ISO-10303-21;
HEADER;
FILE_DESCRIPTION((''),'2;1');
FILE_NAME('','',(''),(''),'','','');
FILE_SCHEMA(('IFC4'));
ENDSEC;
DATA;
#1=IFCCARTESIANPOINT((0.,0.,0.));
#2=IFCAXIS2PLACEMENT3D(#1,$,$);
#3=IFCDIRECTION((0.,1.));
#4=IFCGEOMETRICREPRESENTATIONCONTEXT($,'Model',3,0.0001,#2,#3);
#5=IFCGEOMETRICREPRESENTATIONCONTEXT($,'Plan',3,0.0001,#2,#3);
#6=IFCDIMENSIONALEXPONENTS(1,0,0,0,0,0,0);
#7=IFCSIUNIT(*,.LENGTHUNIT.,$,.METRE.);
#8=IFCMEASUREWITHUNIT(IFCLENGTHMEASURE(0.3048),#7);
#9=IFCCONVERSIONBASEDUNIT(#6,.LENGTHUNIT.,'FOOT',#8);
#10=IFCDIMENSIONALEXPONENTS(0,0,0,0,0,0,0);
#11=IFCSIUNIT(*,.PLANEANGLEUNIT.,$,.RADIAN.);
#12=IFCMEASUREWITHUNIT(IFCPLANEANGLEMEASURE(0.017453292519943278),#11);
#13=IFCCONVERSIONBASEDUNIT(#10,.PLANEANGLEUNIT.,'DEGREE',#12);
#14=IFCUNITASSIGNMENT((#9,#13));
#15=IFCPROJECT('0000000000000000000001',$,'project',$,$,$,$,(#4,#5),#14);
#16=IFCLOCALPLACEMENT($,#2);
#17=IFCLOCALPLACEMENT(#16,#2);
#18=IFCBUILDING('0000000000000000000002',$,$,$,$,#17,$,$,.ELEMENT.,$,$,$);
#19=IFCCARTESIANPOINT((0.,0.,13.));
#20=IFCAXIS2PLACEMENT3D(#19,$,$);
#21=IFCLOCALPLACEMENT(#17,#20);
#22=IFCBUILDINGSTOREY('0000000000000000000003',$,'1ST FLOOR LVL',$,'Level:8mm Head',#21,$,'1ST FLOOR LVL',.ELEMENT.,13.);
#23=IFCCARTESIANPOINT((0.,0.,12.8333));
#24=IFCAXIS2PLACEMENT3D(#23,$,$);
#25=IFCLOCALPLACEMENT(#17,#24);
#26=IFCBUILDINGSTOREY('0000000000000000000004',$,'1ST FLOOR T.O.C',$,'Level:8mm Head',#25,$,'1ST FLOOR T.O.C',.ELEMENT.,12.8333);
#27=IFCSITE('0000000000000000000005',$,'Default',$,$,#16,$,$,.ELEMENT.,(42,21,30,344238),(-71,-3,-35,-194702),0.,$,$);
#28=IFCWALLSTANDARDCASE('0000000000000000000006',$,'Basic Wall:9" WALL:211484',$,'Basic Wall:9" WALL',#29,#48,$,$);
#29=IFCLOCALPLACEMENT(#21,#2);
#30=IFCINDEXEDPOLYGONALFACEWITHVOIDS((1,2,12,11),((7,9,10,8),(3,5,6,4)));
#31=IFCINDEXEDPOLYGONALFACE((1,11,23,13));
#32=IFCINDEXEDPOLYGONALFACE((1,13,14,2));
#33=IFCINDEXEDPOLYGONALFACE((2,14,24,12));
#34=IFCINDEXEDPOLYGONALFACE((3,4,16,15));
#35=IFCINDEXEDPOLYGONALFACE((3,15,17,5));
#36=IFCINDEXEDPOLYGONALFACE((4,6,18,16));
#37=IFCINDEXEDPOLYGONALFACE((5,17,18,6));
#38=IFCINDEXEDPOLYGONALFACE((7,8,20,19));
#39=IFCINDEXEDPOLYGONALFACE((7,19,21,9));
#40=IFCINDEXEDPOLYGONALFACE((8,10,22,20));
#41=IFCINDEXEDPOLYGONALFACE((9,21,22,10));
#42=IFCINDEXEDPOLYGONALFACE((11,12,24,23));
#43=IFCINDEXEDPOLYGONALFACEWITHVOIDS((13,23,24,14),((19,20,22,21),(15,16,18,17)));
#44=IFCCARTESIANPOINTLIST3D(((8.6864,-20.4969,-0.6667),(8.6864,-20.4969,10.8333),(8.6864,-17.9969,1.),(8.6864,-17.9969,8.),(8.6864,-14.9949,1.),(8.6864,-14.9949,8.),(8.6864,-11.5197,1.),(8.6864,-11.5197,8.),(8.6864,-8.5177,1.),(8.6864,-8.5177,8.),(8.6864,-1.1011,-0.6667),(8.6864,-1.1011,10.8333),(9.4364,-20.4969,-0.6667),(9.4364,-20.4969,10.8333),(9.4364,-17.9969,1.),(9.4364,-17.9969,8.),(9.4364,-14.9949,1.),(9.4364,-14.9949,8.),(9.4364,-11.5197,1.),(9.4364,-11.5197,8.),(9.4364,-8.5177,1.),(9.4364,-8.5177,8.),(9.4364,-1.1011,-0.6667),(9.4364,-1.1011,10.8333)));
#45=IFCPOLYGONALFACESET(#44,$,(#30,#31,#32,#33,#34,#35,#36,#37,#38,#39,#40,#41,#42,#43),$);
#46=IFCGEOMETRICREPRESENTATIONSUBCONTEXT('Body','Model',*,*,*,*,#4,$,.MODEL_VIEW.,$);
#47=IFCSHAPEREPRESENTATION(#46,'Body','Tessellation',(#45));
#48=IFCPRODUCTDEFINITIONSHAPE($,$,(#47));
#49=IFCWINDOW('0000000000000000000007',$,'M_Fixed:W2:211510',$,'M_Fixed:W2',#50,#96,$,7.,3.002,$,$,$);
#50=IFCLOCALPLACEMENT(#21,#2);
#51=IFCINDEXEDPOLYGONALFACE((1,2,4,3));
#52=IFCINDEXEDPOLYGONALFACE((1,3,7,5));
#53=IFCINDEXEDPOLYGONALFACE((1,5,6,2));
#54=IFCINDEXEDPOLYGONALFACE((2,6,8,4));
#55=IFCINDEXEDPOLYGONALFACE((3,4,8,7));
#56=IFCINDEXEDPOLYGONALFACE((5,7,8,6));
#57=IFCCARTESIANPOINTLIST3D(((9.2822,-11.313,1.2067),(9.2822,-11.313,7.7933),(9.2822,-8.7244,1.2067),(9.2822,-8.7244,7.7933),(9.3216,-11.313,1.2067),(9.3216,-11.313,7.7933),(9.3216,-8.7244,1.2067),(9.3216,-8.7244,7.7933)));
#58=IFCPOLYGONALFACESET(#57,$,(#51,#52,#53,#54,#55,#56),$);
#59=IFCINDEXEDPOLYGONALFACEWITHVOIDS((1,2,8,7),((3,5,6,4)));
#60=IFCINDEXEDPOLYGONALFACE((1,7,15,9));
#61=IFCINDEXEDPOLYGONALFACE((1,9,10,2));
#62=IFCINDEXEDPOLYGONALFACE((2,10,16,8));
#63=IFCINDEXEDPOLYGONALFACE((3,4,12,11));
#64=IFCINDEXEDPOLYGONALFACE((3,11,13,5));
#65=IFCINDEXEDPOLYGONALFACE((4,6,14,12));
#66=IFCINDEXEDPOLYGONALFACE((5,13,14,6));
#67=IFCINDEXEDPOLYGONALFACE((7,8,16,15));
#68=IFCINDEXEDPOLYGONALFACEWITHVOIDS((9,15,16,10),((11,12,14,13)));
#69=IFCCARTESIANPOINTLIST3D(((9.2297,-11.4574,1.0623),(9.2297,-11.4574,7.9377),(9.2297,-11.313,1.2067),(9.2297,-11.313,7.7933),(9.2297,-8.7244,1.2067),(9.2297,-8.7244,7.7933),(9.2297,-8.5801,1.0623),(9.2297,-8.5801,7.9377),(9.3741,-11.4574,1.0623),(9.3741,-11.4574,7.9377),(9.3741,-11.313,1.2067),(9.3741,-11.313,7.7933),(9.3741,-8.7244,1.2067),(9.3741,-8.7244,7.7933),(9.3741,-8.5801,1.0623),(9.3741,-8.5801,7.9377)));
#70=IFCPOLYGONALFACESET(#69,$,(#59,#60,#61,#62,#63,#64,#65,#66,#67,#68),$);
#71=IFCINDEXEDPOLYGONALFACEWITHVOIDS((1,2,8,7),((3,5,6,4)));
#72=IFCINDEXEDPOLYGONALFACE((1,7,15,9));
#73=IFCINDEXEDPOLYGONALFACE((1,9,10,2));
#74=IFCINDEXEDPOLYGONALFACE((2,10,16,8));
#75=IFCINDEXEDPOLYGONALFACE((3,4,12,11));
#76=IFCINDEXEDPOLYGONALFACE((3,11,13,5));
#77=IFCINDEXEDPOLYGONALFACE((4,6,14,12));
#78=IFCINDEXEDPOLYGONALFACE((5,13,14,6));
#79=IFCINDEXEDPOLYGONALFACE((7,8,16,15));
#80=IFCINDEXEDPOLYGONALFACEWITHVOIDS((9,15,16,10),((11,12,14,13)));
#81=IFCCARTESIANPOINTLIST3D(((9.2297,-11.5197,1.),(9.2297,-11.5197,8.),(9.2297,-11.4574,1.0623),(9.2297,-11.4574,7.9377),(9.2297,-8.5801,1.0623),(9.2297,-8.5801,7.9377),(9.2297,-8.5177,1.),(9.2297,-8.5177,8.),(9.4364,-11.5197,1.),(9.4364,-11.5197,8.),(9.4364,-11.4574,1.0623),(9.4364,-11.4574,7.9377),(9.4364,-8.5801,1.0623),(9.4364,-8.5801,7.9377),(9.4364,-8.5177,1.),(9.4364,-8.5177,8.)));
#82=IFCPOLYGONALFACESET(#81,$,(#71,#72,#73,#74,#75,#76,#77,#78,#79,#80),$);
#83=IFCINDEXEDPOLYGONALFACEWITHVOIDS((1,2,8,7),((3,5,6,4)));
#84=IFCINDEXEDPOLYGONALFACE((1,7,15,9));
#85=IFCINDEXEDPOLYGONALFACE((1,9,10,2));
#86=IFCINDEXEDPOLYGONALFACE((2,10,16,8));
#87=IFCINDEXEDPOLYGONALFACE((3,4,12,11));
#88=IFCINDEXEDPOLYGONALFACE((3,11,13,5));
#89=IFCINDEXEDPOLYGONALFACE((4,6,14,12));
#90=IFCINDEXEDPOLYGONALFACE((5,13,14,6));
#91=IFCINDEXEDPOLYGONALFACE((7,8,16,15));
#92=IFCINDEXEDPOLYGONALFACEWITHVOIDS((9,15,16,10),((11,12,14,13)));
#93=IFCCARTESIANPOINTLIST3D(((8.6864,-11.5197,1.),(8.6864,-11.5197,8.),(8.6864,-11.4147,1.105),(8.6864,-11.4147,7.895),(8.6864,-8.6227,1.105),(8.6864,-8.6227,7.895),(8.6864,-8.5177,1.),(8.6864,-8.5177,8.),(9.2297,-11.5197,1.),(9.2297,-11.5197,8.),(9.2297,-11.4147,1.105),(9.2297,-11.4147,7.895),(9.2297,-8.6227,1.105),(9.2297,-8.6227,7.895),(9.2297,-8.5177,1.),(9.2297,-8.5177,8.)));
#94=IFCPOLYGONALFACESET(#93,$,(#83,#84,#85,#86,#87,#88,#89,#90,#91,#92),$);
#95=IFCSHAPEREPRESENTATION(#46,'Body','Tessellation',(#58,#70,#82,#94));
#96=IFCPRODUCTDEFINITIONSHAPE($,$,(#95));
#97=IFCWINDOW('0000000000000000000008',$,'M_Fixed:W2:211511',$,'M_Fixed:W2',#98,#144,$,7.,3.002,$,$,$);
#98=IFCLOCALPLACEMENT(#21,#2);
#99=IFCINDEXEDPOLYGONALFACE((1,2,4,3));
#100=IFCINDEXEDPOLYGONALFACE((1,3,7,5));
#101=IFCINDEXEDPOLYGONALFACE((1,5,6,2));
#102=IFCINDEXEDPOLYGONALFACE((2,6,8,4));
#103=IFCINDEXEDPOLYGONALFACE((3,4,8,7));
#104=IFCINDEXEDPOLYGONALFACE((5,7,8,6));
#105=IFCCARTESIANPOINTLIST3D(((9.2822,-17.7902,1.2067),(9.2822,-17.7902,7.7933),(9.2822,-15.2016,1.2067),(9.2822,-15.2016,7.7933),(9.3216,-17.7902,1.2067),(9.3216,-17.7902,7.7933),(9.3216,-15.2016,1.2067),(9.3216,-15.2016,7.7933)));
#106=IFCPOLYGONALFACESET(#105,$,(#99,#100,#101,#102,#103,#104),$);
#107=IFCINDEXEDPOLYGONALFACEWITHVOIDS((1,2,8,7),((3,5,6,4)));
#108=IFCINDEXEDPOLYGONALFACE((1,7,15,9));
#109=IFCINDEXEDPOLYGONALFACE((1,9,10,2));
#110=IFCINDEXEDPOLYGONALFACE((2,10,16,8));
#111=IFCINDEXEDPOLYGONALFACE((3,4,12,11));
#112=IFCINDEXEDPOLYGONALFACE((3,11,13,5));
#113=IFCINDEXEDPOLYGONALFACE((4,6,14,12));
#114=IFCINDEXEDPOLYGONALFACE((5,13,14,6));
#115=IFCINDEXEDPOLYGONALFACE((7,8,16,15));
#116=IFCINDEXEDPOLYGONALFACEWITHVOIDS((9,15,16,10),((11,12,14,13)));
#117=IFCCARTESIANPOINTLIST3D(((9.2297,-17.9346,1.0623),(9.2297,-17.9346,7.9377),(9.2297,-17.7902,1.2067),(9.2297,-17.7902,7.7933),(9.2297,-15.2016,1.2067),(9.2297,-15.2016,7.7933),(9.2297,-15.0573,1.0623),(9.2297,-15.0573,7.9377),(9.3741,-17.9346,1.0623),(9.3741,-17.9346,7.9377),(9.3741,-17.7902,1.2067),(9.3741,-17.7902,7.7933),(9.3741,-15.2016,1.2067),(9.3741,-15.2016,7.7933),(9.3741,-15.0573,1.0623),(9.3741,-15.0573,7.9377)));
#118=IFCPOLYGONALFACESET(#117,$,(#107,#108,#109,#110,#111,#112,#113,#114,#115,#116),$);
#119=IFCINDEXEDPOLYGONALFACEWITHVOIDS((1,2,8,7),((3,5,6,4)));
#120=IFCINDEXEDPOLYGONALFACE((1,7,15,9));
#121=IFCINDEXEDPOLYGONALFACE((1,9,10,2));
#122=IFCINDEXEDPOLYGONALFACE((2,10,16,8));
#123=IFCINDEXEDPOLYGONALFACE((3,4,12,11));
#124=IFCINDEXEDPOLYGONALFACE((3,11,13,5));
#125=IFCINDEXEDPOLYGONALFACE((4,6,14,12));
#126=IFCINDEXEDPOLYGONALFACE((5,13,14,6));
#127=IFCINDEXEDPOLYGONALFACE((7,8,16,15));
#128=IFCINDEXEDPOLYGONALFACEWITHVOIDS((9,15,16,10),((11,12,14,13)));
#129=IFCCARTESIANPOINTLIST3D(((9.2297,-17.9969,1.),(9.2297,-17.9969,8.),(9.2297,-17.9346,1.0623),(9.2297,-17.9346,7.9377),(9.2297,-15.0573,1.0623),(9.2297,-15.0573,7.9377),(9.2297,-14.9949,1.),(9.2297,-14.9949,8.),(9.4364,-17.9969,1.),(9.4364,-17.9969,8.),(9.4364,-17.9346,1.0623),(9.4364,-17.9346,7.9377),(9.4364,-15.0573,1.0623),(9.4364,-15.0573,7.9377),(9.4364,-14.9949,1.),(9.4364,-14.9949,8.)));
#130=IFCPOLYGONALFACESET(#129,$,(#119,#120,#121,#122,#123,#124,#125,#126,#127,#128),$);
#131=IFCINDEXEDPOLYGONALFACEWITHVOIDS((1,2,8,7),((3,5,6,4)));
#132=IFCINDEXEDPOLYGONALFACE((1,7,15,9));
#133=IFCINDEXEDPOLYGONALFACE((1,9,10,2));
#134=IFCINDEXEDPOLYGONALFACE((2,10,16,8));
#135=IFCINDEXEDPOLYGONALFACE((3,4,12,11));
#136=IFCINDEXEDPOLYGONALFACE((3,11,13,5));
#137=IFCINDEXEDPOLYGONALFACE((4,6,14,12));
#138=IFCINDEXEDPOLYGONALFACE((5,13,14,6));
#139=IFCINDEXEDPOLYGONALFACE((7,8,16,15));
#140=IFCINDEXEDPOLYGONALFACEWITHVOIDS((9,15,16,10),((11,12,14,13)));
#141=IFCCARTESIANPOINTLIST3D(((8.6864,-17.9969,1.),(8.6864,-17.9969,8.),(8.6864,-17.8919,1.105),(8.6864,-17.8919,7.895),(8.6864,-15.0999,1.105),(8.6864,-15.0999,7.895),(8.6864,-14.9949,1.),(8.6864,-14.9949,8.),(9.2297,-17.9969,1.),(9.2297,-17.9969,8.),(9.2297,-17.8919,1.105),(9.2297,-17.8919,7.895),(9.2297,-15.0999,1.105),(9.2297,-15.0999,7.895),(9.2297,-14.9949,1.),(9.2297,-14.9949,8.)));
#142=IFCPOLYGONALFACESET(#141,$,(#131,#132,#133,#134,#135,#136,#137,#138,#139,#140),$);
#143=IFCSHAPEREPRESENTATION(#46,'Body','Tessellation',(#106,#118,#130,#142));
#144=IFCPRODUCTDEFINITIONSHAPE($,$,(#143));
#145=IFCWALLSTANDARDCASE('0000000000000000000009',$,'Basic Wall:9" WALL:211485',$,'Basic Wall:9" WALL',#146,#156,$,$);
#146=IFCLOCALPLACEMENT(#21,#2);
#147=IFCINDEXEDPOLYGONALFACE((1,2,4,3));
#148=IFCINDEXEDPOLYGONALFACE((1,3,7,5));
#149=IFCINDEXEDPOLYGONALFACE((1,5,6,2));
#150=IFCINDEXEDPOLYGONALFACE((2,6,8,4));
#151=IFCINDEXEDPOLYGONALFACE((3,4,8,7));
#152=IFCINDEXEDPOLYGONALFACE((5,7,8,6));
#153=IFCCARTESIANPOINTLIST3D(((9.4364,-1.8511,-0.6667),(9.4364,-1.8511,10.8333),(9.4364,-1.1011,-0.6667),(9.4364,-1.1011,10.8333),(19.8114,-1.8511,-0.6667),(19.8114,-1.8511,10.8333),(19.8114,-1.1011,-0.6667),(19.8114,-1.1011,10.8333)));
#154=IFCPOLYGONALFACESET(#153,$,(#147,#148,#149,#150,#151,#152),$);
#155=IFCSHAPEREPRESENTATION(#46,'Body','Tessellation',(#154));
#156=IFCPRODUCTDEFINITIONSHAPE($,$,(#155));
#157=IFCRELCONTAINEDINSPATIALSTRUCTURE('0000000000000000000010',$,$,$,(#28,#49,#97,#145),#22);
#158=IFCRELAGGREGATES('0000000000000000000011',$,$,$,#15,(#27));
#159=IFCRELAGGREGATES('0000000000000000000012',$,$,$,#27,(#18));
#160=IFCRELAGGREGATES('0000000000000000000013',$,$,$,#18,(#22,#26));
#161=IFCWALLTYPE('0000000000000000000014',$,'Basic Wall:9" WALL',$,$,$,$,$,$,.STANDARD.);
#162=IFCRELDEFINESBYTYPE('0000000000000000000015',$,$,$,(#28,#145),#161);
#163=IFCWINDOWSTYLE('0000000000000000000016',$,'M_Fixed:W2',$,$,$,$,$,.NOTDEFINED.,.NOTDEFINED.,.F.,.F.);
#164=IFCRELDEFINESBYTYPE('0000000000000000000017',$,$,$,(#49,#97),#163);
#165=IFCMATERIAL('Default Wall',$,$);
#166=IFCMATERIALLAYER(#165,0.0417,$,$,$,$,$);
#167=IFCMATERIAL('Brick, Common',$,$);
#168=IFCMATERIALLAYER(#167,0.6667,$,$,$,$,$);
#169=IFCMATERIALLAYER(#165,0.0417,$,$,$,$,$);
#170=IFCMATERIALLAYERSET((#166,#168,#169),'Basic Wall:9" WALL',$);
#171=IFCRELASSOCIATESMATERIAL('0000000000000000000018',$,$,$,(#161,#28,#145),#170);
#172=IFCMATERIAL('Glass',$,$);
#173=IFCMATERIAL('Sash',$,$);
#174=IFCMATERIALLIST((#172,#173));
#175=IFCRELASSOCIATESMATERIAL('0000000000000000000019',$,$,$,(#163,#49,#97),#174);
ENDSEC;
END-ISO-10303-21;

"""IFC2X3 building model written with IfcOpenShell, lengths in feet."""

from ifc_helpers import new_model, entity, si_unit, converted_unit, direction, frame, frame_2d, origin, place, context, subcontext, project, spatial, polyline, rectangle, outline, extrude, source, transform, mapped, material, material_list, layer, layer_set, layer_usage, type_object, type_shapes, element, fill, save


model = new_model("IFC2X3")

# Units and contexts
model_context = context("Model", 3, precision=0.0001, world=origin(), true_north=direction((0.0, 1.0)))
plan_context = context("Plan", 3, precision=0.0001, world=origin(), true_north=direction((0.0, 1.0)))
body_context = subcontext(model_context, "Body", "Model", "MODEL_VIEW")
ifc_project = project(units=[converted_unit("LENGTHUNIT", "FOOT", entity("IfcLengthMeasure", 0.3048), si_unit("LENGTHUNIT", "METRE"), dimensions=[1, 0, 0, 0, 0, 0, 0]), converted_unit("PLANEANGLEUNIT", "DEGREE", entity("IfcPlaneAngleMeasure", 0.017453292519943278), si_unit("PLANEANGLEUNIT", "RADIAN"), dimensions=[0, 0, 0, 0, 0, 0, 0])], contexts=[model_context, plan_context])

# Site, building, storey
site_placement = place(None, origin())
site = spatial("IfcSite", under=ifc_project, at=site_placement, Name="Default", CompositionType="ELEMENT", RefLatitude=(42, 21, 30, 344238), RefLongitude=(-71, -3, -35, -194702), RefElevation=0.0)
building_placement = place(site_placement, origin())
building = spatial("IfcBuilding", under=site, at=building_placement, CompositionType="ELEMENT")
storey_1_placement = place(building_placement, frame((0.0, 0.0, 13.0)))
storey_1 = spatial("IfcBuildingStorey", under=building, at=storey_1_placement, Name="1ST FLOOR LVL", ObjectType="Level:8mm Head", LongName="1ST FLOOR LVL", CompositionType="ELEMENT", Elevation=13.0)

# Shared definitions
ifc_material_1 = material(Name="Default Wall")
ifc_layer_1 = layer(ifc_material_1, 0.0417)
ifc_material_2 = material(Name="Brick, Common")
ifc_layer_2 = layer(ifc_material_2, 0.6667)
ifc_layer_3 = layer(ifc_material_1, 0.0417)
ifc_layer_set_1 = layer_set([ifc_layer_1, ifc_layer_2, ifc_layer_3], Name="Basic Wall:9\" WALL")
wall_type_1 = type_object("IfcWallType", Name="Basic Wall:9\" WALL", PredefinedType="STANDARD", material=ifc_layer_set_1)
ifc_material_3 = material(Name="Glass")
ifc_material_4 = material(Name="Sash")

# Shared definitions
storey_2_placement = place(building_placement, frame((0.0, 0.0, 12.8333)))
storey_2 = spatial("IfcBuildingStorey", under=building, at=storey_2_placement, Name="1ST FLOOR T.O.C", ObjectType="Level:8mm Head", LongName="1ST FLOOR T.O.C", CompositionType="ELEMENT", Elevation=12.8333)

# Wall, openings, windows
ifc_layer_usage_1 = layer_usage(ifc_layer_set_1, "AXIS2", "NEGATIVE", 0.375)
wall_1_placement = place(storey_1_placement, frame((9.0614, -20.4969, -0.6667), z_axis=(0.0, 0.0, 1.0), x_axis=(0.0, 1.0, 0.0)))
wall_1 = element("IfcWallStandardCase", 1, at=wall_1_placement, inside=storey_1, type_object=wall_type_1, material=ifc_layer_usage_1, Name="Basic Wall:9\" WALL:211484", ObjectType="Basic Wall:9\" WALL", context=body_context, shape_type="SweptSolid", body=[
    extrude(rectangle(XDim=19.3958, YDim=0.75, at=frame_2d((9.6979, 0.0), x_axis=(-1.0, 0.0))), origin(), (0.0, 0.0, 1.0), 11.5),
])
opening_1_placement = place(wall_1_placement, frame((11.9792, 0.375, 1.6667)))
opening_1 = element("IfcOpeningElement", 2, at=opening_1_placement, cuts=wall_1, ObjectType="Opening", context=body_context, shape_type="SweptSolid", body=[
    extrude(rectangle(XDim=7.0, YDim=3.002, at=frame_2d((3.5, 1.501), x_axis=(1.0, 0.0))), frame((0.0, 0.0, 0.0), z_axis=(0.0, -1.0, 0.0), x_axis=(0.0, 0.0, 1.0)), (0.0, 0.0, 1.0), 0.75),
])
opening_2_placement = place(wall_1_placement, frame((5.502, 0.375, 1.6667)))
opening_2 = element("IfcOpeningElement", 3, at=opening_2_placement, cuts=wall_1, ObjectType="Opening", context=body_context, shape_type="SweptSolid", body=[
    extrude(rectangle(XDim=7.0, YDim=3.002, at=frame_2d((3.5, 1.501), x_axis=(1.0, 0.0))), frame((0.0, 0.0, 0.0), z_axis=(0.0, -1.0, 0.0), x_axis=(0.0, 0.0, 1.0)), (0.0, 0.0, 1.0), 0.75),
])
ifc_material_list_1 = material_list([ifc_material_3, ifc_material_4])
window_style_1 = type_object("IfcWindowStyle", Name="M_Fixed:W2", ConstructionType="NOTDEFINED", OperationType="NOTDEFINED", ParameterTakesPrecedence=False, Sizeable=False, material=ifc_material_list_1)
shared_shape_1 = source(origin(), body_context, "Body", "SweptSolid", [
    extrude(rectangle(XDim=0.0394, YDim=2.5886, at=frame_2d((0.0, 0.0), x_axis=(1.0, 0.0))), frame((1.501, 0.6155, 0.2067), z_axis=(0.0, 0.0, 1.0), x_axis=(0.0, -1.0, 0.0)), (0.0, 0.0, 1.0), 6.5866),
    extrude(outline(polyline([(-1.4386, -3.4377), (1.4386, -3.4377), (1.4386, 3.4377), (-1.4386, 3.4377), (-1.4386, -3.4377)]), holes=[polyline([(-1.2943, -3.2933), (-1.2943, 3.2933), (1.2943, 3.2933), (1.2943, -3.2933), (-1.2943, -3.2933)])]), frame((1.501, 0.5433, 3.5), z_axis=(0.0, 1.0, 0.0), x_axis=(1.0, 0.0, 0.0)), (0.0, 0.0, 1.0), 0.1444),
    extrude(outline(polyline([(-1.501, -3.5), (1.501, -3.5), (1.501, 3.5), (-1.501, 3.5), (-1.501, -3.5)]), holes=[polyline([(-1.4386, -3.4377), (-1.4386, 3.4377), (1.4386, 3.4377), (1.4386, -3.4377), (-1.4386, -3.4377)])]), frame((1.501, 0.5433, 3.5), z_axis=(0.0, 1.0, 0.0), x_axis=(1.0, 0.0, 0.0)), (0.0, 0.0, 1.0), 0.2067),
    extrude(outline(polyline([(-1.501, -3.5), (1.501, -3.5), (1.501, 3.5), (-1.501, 3.5), (-1.501, -3.5)]), holes=[polyline([(-1.396, -3.395), (-1.396, 3.395), (1.396, 3.395), (1.396, -3.395), (-1.396, -3.395)])]), frame((1.501, 0.0, 3.5), z_axis=(0.0, 1.0, 0.0), x_axis=(1.0, 0.0, 0.0)), (0.0, 0.0, 1.0), 0.5433),
])
type_shapes(window_style_1, [shared_shape_1])
window_1_placement = place(opening_1_placement, frame((0.0, 0.0, 0.0), z_axis=(0.0, 0.0, 1.0), x_axis=(-1.0, 0.0, 0.0)))
window_1 = element("IfcWindow", 4, at=window_1_placement, inside=storey_1, type_object=window_style_1, material=ifc_material_list_1, Name="M_Fixed:W2:211510", ObjectType="M_Fixed:W2", OverallHeight=7.0, OverallWidth=3.002, context=body_context, shape_type="MappedRepresentation", body=[
    mapped(shared_shape_1, transform((0.0, 0.0, 0.0), scale=1.0)),
])
fill(opening_1, window_1)
window_2_placement = place(opening_2_placement, frame((0.0, 0.0, 0.0), z_axis=(0.0, 0.0, 1.0), x_axis=(-1.0, 0.0, 0.0)))
window_2 = element("IfcWindow", 5, at=window_2_placement, inside=storey_1, type_object=window_style_1, material=ifc_material_list_1, Name="M_Fixed:W2:211511", ObjectType="M_Fixed:W2", OverallHeight=7.0, OverallWidth=3.002, context=body_context, shape_type="MappedRepresentation", body=[
    mapped(shared_shape_1, transform((0.0, 0.0, 0.0), scale=1.0)),
])
fill(opening_2, window_2)

# Wall
ifc_layer_usage_2 = layer_usage(ifc_layer_set_1, "AXIS2", "NEGATIVE", 0.375)
wall_2_placement = place(storey_1_placement, frame((19.8114, -1.4761, -0.6667), z_axis=(0.0, 0.0, 1.0), x_axis=(-1.0, 0.0, 0.0)))
element("IfcWallStandardCase", 6, at=wall_2_placement, inside=storey_1, type_object=wall_type_1, material=ifc_layer_usage_2, Name="Basic Wall:9\" WALL:211485", ObjectType="Basic Wall:9\" WALL", context=body_context, shape_type="SweptSolid", body=[
    extrude(rectangle(XDim=10.375, YDim=0.75, at=frame_2d((5.1875, 0.0), x_axis=(-1.0, 0.0))), origin(), (0.0, 0.0, 1.0), 11.5),
])

save(model, "model.ifc")
